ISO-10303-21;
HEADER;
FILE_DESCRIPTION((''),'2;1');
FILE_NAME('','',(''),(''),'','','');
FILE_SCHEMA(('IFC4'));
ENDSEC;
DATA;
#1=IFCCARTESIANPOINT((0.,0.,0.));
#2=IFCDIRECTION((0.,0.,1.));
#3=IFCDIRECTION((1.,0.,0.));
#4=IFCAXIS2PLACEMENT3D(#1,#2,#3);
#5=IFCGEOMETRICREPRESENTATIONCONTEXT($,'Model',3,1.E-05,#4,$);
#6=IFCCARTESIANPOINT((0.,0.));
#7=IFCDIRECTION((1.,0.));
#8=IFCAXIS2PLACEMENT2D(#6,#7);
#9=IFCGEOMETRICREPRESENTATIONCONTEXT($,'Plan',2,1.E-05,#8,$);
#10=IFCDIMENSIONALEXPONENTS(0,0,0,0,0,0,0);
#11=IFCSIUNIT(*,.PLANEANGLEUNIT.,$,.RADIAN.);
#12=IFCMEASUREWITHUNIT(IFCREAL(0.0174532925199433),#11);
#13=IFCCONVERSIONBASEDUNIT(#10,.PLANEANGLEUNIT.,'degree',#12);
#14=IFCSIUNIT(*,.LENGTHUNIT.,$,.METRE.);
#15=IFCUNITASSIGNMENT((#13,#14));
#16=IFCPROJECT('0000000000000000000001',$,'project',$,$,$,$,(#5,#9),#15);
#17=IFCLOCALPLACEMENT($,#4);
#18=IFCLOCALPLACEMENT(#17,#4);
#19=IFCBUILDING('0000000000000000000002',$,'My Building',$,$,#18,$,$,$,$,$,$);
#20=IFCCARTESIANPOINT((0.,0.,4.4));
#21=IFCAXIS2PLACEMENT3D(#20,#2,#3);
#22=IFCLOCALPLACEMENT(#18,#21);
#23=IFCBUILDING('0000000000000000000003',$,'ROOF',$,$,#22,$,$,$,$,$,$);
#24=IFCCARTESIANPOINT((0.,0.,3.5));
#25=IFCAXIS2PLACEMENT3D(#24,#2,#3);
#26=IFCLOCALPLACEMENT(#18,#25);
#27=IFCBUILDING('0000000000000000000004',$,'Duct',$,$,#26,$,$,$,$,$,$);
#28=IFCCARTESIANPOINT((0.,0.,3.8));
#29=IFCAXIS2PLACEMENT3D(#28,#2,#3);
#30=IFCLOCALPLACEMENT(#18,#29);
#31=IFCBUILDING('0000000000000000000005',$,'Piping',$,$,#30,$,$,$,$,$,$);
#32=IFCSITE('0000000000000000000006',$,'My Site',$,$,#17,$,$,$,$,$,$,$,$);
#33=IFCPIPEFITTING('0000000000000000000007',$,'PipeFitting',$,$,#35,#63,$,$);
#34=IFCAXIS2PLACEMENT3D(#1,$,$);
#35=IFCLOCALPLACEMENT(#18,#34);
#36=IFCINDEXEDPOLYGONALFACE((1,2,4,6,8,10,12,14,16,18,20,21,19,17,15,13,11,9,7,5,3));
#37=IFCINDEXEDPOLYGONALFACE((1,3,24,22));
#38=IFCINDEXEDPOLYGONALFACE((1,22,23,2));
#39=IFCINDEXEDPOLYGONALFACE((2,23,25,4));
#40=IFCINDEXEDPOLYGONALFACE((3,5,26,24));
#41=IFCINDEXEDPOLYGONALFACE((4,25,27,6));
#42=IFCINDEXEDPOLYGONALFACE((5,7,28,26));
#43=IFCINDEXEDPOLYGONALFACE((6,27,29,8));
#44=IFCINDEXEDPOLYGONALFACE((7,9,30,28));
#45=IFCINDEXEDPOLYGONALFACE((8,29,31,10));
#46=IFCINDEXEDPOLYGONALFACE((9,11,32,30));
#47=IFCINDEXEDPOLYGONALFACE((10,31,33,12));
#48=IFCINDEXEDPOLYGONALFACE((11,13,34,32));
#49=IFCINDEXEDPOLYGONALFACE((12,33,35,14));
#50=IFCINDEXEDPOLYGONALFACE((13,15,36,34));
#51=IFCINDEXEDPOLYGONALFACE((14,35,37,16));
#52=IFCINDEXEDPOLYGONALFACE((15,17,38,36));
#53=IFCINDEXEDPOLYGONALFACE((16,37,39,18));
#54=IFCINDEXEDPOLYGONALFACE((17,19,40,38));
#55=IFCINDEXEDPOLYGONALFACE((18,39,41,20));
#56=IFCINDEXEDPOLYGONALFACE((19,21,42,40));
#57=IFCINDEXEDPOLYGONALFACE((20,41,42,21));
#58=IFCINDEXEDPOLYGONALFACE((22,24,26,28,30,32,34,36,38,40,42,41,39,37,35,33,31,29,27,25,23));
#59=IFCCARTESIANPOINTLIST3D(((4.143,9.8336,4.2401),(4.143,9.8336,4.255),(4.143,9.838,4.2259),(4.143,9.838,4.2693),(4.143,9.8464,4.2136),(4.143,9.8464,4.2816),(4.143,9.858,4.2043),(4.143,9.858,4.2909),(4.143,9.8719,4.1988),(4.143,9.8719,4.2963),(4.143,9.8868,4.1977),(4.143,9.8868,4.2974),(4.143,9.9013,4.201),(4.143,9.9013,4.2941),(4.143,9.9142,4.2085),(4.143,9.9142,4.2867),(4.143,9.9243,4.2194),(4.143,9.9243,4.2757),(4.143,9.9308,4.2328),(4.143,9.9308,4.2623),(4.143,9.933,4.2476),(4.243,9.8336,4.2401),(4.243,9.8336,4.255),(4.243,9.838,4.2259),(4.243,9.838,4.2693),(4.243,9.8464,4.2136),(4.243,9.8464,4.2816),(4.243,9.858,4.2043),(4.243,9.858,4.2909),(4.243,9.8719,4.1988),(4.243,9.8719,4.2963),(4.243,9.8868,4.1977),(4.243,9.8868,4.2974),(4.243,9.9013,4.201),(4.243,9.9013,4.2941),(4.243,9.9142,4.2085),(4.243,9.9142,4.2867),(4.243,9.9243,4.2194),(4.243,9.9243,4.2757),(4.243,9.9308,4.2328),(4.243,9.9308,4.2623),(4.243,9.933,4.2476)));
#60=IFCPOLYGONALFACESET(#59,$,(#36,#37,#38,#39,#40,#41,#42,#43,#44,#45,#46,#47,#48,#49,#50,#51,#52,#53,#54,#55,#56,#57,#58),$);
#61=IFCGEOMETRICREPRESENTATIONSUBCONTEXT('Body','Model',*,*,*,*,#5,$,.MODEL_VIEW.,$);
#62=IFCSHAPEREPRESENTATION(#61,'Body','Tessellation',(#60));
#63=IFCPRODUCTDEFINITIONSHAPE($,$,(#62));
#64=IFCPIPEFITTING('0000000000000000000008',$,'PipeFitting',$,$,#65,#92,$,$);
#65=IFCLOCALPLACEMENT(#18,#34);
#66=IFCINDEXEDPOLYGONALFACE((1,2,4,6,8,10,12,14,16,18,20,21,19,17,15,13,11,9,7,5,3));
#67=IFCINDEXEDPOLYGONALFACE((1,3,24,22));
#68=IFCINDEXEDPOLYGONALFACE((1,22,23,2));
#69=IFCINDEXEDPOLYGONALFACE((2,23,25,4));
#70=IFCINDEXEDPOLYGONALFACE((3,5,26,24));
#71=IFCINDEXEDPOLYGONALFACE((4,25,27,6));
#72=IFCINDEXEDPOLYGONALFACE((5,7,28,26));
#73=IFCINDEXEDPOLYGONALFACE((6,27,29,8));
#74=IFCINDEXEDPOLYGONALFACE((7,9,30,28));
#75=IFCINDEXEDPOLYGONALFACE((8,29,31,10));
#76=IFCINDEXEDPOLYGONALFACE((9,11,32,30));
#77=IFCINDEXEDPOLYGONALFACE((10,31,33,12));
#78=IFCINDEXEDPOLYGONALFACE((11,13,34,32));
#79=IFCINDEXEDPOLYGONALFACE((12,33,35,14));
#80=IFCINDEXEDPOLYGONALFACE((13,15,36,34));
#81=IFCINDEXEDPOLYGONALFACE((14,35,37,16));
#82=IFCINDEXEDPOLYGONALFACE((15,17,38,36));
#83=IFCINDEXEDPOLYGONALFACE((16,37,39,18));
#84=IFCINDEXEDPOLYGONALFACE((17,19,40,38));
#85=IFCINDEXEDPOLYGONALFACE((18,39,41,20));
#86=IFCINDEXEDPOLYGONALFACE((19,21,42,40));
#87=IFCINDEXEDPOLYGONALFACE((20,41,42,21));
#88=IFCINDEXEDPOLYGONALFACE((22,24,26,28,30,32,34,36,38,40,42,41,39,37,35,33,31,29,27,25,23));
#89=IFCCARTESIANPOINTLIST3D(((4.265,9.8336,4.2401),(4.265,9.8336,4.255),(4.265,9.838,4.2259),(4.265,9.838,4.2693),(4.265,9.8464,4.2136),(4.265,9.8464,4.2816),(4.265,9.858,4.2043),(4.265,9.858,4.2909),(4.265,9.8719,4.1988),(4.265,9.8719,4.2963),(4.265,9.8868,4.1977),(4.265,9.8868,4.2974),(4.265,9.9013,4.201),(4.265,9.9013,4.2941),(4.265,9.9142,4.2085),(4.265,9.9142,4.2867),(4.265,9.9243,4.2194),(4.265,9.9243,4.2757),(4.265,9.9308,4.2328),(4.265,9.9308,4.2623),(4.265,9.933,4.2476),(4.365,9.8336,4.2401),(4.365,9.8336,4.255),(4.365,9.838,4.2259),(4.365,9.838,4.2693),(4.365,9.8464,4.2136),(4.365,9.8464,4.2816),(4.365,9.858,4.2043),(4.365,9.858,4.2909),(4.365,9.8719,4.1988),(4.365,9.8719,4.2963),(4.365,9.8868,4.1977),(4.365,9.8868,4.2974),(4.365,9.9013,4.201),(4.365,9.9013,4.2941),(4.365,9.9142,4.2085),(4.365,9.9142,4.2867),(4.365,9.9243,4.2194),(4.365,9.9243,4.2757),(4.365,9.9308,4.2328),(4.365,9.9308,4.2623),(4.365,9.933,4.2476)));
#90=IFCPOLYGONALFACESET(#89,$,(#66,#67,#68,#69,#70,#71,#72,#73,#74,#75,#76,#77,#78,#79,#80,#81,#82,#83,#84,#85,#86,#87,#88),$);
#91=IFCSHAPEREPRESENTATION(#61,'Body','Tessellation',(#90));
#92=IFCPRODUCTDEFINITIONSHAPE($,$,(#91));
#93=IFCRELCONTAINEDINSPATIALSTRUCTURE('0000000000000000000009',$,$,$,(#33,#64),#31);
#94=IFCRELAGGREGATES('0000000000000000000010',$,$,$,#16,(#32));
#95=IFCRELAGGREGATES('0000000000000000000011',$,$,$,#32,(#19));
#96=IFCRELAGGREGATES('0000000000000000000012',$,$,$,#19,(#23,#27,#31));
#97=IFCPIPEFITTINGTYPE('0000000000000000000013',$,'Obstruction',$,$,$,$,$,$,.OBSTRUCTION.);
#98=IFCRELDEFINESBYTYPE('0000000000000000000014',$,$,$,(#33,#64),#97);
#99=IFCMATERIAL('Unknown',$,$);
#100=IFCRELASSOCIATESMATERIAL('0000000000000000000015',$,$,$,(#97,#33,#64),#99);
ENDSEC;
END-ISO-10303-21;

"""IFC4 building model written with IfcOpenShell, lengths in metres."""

from ifc_helpers import new_model, entity, si_unit, converted_unit, frame, origin_with_axes, origin_2d_with_axis, place, context, subcontext, project, spatial, circle, extrude, material, material_profile, profile_set, profile_usage, type_object, element, save


model = new_model("IFC4")

# Units and contexts
model_context = context("Model", 3, precision=1e-05, world=origin_with_axes())
plan_context = context("Plan", 2, precision=1e-05, world=origin_2d_with_axis())
body_context_1 = subcontext(model_context, "Body", "Model", "MODEL_VIEW")
ifc_project = project(units=[converted_unit("PLANEANGLEUNIT", "degree", entity("IfcReal", 0.0174532925199433), si_unit("PLANEANGLEUNIT", "RADIAN"), dimensions=[0, 0, 0, 0, 0, 0, 0]), si_unit("LENGTHUNIT", "METRE")], contexts=[model_context, plan_context])

# Site, building
site_placement = place(None, origin_with_axes())
site = spatial("IfcSite", under=ifc_project, at=site_placement, Name="My Site")
building_1_placement = place(site_placement, origin_with_axes())
building_1 = spatial("IfcBuilding", under=site, at=building_1_placement, Name="My Building")

# Shared definitions
ifc_material = material(Name="Unknown")

# Shared definitions
building_2_placement = place(building_1_placement, frame((0.0, 0.0, 4.4), z_axis=(0.0, 0.0, 1.0), x_axis=(1.0, 0.0, 0.0)))
building_2 = spatial("IfcBuilding", under=building_1, at=building_2_placement, Name="ROOF")

# Shared definitions
building_3_placement = place(building_1_placement, frame((0.0, 0.0, 3.5), z_axis=(0.0, 0.0, 1.0), x_axis=(1.0, 0.0, 0.0)))
building_3 = spatial("IfcBuilding", under=building_1, at=building_3_placement, Name="Duct")

# Shared definitions
building_4_placement = place(building_1_placement, frame((0.0, 0.0, 3.8), z_axis=(0.0, 0.0, 1.0), x_axis=(1.0, 0.0, 0.0)))
building_4 = spatial("IfcBuilding", under=building_1, at=building_4_placement, Name="Piping")

# Pipe fittings
ifc_material_profile_1 = material_profile(ifc_material, circle(Radius=0.05))
ifc_profile_set_1 = profile_set([ifc_material_profile_1])
ifc_profile_usage_1 = profile_usage(ifc_profile_set_1, cardinal=5)
pipe_fitting_type_1 = type_object("IfcPipeFittingType", Name="Obstruction", PredefinedType="OBSTRUCTION", material=ifc_profile_set_1)
pipe_fitting_1_placement = place(building_4_placement, frame((4.243, 9.883, 0.4476), z_axis=(-1.0, -0.000001, -0.000001), x_axis=(-0.000001, 1.0, 0.0)))
element("IfcPipeFitting", 1, at=pipe_fitting_1_placement, inside=building_4, type_object=pipe_fitting_type_1, material=ifc_profile_usage_1, Name="PipeFitting", context=body_context_1, shape_type="SweptSolid", body=[
    extrude(circle(Radius=0.05), origin_with_axes(), (0.0, 0.0, 1.0), 0.1),
])
ifc_profile_usage_2 = profile_usage(ifc_profile_set_1, cardinal=5)
pipe_fitting_2_placement = place(building_4_placement, frame((4.265, 9.883, 0.4476), z_axis=(1.0, -0.000001, 0.000001), x_axis=(0.000001, 1.0, 0.0)))
element("IfcPipeFitting", 2, at=pipe_fitting_2_placement, inside=building_4, type_object=pipe_fitting_type_1, material=ifc_profile_usage_2, Name="PipeFitting", context=body_context_1, shape_type="SweptSolid", body=[
    extrude(circle(Radius=0.05), origin_with_axes(), (0.0, 0.0, 1.0), 0.1),
])

save(model, "model.ifc")
